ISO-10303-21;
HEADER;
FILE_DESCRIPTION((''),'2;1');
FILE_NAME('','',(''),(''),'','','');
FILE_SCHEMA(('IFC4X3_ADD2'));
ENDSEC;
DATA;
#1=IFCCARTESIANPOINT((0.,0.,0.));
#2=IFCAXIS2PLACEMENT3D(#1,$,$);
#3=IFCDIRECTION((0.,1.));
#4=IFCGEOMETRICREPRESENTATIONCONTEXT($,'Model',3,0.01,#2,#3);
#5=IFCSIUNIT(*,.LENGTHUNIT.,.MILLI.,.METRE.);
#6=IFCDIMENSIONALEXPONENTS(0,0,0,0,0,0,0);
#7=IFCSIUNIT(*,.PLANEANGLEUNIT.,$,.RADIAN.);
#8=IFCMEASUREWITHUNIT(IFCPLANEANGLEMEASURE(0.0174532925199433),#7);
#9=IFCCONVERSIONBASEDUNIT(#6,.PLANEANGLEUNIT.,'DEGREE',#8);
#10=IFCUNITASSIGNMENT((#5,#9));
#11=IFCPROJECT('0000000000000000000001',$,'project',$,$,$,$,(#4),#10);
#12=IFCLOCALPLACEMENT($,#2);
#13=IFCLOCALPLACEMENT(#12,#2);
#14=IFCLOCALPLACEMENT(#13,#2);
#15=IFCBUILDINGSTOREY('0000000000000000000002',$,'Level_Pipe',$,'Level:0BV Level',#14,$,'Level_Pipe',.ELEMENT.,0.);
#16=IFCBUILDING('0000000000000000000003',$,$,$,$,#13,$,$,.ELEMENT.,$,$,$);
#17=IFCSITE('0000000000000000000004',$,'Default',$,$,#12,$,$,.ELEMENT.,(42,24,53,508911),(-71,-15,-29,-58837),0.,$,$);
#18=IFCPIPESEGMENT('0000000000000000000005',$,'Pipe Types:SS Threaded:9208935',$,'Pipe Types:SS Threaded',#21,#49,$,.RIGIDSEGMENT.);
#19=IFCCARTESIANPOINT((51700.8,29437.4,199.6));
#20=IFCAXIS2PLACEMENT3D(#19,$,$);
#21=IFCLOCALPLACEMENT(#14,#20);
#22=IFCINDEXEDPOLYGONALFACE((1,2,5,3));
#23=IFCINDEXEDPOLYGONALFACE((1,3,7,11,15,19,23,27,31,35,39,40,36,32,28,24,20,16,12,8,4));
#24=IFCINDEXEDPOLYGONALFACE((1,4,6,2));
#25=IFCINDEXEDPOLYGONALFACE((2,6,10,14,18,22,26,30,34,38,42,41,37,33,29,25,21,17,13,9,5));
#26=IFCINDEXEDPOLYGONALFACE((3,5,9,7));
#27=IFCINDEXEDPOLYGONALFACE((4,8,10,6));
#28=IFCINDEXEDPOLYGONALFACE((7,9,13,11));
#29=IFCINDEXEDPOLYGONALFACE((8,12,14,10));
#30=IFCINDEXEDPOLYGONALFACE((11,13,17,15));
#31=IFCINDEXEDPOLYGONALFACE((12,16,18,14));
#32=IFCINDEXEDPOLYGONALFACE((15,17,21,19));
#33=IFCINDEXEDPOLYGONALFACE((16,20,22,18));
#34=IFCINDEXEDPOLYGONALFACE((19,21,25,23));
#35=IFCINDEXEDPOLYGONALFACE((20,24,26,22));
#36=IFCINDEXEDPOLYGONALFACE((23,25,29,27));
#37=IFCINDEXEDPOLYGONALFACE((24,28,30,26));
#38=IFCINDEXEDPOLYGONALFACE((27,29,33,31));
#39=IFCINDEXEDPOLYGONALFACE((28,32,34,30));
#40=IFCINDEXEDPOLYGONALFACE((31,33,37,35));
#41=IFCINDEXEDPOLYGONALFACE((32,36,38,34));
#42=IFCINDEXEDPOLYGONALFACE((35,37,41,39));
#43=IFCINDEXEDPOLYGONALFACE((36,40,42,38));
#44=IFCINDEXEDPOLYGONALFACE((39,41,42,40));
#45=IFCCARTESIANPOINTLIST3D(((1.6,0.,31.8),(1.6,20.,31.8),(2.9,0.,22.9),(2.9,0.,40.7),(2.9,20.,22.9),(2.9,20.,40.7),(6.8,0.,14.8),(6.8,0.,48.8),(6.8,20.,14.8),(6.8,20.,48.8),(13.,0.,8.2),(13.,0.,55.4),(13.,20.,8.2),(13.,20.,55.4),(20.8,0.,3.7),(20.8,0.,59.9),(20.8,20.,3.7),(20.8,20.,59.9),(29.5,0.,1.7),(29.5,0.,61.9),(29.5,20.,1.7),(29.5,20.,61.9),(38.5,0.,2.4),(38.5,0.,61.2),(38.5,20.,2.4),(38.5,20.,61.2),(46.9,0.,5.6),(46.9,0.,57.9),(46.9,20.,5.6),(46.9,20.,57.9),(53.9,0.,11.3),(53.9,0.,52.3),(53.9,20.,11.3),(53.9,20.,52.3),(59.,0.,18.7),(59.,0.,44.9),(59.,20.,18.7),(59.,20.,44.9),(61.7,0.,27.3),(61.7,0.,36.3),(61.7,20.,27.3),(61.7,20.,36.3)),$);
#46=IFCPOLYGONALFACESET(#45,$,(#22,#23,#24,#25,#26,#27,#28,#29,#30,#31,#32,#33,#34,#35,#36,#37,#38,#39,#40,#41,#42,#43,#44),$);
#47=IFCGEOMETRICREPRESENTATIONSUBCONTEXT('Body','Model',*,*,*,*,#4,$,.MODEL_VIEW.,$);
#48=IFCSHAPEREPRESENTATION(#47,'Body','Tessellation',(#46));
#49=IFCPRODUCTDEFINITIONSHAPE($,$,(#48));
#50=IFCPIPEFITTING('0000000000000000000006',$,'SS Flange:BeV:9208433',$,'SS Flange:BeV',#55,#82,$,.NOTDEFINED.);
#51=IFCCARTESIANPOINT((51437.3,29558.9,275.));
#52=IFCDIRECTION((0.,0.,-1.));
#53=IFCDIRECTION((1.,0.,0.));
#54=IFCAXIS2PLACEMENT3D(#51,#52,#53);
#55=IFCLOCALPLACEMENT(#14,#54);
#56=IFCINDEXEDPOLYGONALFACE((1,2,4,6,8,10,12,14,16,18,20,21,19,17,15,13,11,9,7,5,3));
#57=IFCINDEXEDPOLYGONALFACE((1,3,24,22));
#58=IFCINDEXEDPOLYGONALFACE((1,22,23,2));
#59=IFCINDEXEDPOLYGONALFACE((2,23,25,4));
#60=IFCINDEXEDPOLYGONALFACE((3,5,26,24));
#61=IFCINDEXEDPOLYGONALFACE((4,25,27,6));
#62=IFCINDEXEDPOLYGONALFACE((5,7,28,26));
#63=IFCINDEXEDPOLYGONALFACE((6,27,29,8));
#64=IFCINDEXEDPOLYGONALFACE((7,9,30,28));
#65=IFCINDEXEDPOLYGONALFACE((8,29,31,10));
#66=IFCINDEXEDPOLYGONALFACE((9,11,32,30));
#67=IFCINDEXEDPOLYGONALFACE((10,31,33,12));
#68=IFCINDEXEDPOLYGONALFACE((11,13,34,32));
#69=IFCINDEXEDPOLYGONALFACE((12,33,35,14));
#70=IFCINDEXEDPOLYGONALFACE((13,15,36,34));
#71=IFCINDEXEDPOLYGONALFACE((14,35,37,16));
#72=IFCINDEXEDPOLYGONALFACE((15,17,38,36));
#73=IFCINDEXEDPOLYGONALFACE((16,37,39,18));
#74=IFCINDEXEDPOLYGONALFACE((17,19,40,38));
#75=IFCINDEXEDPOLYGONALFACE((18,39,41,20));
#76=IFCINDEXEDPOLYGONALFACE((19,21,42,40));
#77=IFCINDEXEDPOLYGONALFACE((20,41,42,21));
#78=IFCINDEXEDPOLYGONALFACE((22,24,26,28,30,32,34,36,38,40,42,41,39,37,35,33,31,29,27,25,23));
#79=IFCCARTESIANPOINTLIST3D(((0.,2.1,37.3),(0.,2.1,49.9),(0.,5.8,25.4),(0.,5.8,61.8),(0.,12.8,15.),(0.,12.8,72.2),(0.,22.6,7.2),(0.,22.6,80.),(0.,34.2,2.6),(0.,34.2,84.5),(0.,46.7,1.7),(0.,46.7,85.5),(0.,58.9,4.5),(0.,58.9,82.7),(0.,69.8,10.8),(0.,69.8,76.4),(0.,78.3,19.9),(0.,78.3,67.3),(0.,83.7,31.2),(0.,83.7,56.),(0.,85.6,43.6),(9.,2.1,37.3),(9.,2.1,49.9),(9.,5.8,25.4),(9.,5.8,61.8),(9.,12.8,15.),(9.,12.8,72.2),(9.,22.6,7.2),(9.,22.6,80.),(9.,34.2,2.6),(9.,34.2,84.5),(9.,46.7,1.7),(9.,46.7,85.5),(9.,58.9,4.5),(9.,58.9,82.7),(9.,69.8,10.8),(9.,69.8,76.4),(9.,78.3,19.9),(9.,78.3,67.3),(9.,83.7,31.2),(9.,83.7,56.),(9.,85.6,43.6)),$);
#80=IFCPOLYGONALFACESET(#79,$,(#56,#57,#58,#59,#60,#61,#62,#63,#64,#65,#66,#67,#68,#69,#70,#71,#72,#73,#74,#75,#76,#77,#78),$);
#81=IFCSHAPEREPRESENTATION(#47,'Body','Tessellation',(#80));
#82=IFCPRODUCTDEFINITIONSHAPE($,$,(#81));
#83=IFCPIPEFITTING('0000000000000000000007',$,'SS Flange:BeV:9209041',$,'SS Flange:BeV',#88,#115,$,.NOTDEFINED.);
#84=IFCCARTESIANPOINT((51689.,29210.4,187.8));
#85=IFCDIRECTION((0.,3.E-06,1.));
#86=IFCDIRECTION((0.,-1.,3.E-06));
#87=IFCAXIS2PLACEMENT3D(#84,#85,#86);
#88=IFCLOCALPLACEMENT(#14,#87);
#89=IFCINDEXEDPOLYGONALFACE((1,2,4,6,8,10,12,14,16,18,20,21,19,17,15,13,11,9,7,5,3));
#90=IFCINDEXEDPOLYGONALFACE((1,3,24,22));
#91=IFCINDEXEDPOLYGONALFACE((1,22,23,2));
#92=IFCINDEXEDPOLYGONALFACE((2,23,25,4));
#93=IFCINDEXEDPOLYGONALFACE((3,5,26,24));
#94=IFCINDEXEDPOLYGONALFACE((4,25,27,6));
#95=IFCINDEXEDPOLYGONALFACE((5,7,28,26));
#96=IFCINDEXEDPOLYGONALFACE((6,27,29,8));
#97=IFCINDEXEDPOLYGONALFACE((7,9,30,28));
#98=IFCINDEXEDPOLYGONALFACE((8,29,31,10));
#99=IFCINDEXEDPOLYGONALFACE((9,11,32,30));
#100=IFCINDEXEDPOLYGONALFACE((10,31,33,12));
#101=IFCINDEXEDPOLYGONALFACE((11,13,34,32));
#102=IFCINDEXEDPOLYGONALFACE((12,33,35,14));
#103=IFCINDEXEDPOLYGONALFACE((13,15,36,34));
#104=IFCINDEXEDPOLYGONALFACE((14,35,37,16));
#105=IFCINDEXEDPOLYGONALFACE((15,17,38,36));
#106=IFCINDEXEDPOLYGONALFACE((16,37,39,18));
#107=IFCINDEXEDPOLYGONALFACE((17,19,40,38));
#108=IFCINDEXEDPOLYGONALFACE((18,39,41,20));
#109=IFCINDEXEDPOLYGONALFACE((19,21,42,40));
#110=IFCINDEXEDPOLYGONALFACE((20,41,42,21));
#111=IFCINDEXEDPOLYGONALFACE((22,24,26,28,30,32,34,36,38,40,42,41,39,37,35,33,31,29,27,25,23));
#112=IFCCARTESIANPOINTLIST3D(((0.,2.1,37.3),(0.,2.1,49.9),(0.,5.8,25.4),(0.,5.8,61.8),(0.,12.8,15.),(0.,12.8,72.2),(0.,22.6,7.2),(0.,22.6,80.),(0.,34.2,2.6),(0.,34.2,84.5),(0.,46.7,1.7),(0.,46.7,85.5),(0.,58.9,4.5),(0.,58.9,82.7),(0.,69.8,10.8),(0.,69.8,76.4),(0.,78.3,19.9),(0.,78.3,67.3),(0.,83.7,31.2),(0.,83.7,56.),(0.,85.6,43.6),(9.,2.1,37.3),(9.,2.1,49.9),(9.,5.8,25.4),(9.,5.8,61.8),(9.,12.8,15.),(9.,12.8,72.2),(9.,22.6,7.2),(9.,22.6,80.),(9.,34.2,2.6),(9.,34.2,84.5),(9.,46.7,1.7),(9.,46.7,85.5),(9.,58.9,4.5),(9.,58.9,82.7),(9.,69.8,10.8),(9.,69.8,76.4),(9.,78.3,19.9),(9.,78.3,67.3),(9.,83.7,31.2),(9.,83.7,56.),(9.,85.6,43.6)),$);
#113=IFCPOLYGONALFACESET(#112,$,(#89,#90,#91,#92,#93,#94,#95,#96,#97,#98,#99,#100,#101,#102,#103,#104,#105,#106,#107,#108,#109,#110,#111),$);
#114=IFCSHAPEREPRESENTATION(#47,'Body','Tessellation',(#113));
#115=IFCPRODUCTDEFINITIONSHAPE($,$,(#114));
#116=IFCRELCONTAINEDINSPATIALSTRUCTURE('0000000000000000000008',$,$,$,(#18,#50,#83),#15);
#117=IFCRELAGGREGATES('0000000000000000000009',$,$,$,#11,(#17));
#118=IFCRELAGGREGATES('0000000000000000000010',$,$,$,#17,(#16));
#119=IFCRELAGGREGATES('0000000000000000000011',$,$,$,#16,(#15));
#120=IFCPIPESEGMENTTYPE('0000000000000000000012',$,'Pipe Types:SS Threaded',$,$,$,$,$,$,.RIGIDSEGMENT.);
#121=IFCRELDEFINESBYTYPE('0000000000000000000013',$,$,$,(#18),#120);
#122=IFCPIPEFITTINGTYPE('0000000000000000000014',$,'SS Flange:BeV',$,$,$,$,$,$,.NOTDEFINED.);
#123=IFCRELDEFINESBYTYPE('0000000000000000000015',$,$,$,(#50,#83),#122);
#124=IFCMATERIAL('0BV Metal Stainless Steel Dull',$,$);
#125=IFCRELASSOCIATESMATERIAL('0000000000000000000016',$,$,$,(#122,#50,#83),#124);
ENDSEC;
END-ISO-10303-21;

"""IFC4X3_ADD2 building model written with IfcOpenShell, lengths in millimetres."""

from ifc_helpers import new_model, entity, si_unit, converted_unit, direction, frame, frame_2d, origin, place, context, subcontext, project, spatial, circle, extrude, source, transform, mapped, material, type_object, type_shapes, element, save


model = new_model("IFC4X3_ADD2")

# Units and contexts
model_context = context("Model", 3, precision=0.01, world=origin(), true_north=direction((0.0, 1.0)))
body_context = subcontext(model_context, "Body", "Model", "MODEL_VIEW")
ifc_project = project(units=[si_unit("LENGTHUNIT", "METRE", prefix="MILLI"), converted_unit("PLANEANGLEUNIT", "DEGREE", entity("IfcPlaneAngleMeasure", 0.0174532925199433), si_unit("PLANEANGLEUNIT", "RADIAN"), dimensions=[0, 0, 0, 0, 0, 0, 0])], contexts=[model_context])

# Site, building, storey
site_placement = place(None, origin())
site = spatial("IfcSite", under=ifc_project, at=site_placement, Name="Default", CompositionType="ELEMENT", RefLatitude=(42, 24, 53, 508911), RefLongitude=(-71, -15, -29, -58837), RefElevation=0.0)
building_placement = place(site_placement, origin())
building = spatial("IfcBuilding", under=site, at=building_placement, CompositionType="ELEMENT")
storey_placement = place(building_placement, origin())
storey = spatial("IfcBuildingStorey", under=building, at=storey_placement, Name="Level_Pipe", ObjectType="Level:0BV Level", LongName="Level_Pipe", CompositionType="ELEMENT", Elevation=0.0)

# Pipe segment
pipe_segment_type_1 = type_object("IfcPipeSegmentType", Name="Pipe Types:SS Threaded", PredefinedType="RIGIDSEGMENT")
pipe_segment_1_placement = place(storey_placement, frame((51700.8, 29437.4, 199.6)))
element("IfcPipeSegment", 1, at=pipe_segment_1_placement, inside=storey, type_object=pipe_segment_type_1, Name="Pipe Types:SS Threaded:9208935", ObjectType="Pipe Types:SS Threaded", PredefinedType="RIGIDSEGMENT", context=body_context, shape_type="SweptSolid", body=[
    extrude(circle(Radius=30.2, at=frame_2d((0.0, 0.0), x_axis=(1.0, 0.0))), frame((31.8, 0.0, 31.8), z_axis=(0.0, 1.0, 0.0), x_axis=(-1.0, 0.0, 0.0)), (0.0, 0.0, 1.0), 20.0),
])

# Pipe fittings
ifc_material_1 = material(Name="0BV Metal Stainless Steel Dull")
pipe_fitting_type_1 = type_object("IfcPipeFittingType", Name="SS Flange:BeV", PredefinedType="NOTDEFINED", material=ifc_material_1)
shared_shape_1 = source(origin(), body_context, "Body", "SweptSolid", [
    extrude(circle(Radius=42.0, at=frame_2d((0.0, 0.0), x_axis=(1.0, 0.0))), frame((0.0, 43.6, 43.6), z_axis=(1.0, 0.0, 0.0), x_axis=(0.0, 1.0, 0.0)), (0.0, 0.0, 1.0), 9.0),
])
type_shapes(pipe_fitting_type_1, [shared_shape_1])
for number, where, z_axis, x_axis, name in (
    (2, (51437.3, 29558.9, 275.0), (0.0, 0.0, -1.0), (1.0, 0.0, 0.0), "SS Flange:BeV:9208433"),
    (3, (51689.0, 29210.4, 187.8), (0.0, 0.000003, 1.0), (0.0, -1.0, 0.000003), "SS Flange:BeV:9209041"),
):
    element("IfcPipeFitting", number, at=place(storey_placement, frame(where, z_axis=z_axis, x_axis=x_axis)), inside=storey, type_object=pipe_fitting_type_1, material=ifc_material_1, Name=name, ObjectType="SS Flange:BeV", PredefinedType="NOTDEFINED", context=body_context, shape_type="MappedRepresentation", body=[
        mapped(shared_shape_1, transform((0.0, 0.0, 0.0), scale=1.0)),
    ])

save(model, "model.ifc")
